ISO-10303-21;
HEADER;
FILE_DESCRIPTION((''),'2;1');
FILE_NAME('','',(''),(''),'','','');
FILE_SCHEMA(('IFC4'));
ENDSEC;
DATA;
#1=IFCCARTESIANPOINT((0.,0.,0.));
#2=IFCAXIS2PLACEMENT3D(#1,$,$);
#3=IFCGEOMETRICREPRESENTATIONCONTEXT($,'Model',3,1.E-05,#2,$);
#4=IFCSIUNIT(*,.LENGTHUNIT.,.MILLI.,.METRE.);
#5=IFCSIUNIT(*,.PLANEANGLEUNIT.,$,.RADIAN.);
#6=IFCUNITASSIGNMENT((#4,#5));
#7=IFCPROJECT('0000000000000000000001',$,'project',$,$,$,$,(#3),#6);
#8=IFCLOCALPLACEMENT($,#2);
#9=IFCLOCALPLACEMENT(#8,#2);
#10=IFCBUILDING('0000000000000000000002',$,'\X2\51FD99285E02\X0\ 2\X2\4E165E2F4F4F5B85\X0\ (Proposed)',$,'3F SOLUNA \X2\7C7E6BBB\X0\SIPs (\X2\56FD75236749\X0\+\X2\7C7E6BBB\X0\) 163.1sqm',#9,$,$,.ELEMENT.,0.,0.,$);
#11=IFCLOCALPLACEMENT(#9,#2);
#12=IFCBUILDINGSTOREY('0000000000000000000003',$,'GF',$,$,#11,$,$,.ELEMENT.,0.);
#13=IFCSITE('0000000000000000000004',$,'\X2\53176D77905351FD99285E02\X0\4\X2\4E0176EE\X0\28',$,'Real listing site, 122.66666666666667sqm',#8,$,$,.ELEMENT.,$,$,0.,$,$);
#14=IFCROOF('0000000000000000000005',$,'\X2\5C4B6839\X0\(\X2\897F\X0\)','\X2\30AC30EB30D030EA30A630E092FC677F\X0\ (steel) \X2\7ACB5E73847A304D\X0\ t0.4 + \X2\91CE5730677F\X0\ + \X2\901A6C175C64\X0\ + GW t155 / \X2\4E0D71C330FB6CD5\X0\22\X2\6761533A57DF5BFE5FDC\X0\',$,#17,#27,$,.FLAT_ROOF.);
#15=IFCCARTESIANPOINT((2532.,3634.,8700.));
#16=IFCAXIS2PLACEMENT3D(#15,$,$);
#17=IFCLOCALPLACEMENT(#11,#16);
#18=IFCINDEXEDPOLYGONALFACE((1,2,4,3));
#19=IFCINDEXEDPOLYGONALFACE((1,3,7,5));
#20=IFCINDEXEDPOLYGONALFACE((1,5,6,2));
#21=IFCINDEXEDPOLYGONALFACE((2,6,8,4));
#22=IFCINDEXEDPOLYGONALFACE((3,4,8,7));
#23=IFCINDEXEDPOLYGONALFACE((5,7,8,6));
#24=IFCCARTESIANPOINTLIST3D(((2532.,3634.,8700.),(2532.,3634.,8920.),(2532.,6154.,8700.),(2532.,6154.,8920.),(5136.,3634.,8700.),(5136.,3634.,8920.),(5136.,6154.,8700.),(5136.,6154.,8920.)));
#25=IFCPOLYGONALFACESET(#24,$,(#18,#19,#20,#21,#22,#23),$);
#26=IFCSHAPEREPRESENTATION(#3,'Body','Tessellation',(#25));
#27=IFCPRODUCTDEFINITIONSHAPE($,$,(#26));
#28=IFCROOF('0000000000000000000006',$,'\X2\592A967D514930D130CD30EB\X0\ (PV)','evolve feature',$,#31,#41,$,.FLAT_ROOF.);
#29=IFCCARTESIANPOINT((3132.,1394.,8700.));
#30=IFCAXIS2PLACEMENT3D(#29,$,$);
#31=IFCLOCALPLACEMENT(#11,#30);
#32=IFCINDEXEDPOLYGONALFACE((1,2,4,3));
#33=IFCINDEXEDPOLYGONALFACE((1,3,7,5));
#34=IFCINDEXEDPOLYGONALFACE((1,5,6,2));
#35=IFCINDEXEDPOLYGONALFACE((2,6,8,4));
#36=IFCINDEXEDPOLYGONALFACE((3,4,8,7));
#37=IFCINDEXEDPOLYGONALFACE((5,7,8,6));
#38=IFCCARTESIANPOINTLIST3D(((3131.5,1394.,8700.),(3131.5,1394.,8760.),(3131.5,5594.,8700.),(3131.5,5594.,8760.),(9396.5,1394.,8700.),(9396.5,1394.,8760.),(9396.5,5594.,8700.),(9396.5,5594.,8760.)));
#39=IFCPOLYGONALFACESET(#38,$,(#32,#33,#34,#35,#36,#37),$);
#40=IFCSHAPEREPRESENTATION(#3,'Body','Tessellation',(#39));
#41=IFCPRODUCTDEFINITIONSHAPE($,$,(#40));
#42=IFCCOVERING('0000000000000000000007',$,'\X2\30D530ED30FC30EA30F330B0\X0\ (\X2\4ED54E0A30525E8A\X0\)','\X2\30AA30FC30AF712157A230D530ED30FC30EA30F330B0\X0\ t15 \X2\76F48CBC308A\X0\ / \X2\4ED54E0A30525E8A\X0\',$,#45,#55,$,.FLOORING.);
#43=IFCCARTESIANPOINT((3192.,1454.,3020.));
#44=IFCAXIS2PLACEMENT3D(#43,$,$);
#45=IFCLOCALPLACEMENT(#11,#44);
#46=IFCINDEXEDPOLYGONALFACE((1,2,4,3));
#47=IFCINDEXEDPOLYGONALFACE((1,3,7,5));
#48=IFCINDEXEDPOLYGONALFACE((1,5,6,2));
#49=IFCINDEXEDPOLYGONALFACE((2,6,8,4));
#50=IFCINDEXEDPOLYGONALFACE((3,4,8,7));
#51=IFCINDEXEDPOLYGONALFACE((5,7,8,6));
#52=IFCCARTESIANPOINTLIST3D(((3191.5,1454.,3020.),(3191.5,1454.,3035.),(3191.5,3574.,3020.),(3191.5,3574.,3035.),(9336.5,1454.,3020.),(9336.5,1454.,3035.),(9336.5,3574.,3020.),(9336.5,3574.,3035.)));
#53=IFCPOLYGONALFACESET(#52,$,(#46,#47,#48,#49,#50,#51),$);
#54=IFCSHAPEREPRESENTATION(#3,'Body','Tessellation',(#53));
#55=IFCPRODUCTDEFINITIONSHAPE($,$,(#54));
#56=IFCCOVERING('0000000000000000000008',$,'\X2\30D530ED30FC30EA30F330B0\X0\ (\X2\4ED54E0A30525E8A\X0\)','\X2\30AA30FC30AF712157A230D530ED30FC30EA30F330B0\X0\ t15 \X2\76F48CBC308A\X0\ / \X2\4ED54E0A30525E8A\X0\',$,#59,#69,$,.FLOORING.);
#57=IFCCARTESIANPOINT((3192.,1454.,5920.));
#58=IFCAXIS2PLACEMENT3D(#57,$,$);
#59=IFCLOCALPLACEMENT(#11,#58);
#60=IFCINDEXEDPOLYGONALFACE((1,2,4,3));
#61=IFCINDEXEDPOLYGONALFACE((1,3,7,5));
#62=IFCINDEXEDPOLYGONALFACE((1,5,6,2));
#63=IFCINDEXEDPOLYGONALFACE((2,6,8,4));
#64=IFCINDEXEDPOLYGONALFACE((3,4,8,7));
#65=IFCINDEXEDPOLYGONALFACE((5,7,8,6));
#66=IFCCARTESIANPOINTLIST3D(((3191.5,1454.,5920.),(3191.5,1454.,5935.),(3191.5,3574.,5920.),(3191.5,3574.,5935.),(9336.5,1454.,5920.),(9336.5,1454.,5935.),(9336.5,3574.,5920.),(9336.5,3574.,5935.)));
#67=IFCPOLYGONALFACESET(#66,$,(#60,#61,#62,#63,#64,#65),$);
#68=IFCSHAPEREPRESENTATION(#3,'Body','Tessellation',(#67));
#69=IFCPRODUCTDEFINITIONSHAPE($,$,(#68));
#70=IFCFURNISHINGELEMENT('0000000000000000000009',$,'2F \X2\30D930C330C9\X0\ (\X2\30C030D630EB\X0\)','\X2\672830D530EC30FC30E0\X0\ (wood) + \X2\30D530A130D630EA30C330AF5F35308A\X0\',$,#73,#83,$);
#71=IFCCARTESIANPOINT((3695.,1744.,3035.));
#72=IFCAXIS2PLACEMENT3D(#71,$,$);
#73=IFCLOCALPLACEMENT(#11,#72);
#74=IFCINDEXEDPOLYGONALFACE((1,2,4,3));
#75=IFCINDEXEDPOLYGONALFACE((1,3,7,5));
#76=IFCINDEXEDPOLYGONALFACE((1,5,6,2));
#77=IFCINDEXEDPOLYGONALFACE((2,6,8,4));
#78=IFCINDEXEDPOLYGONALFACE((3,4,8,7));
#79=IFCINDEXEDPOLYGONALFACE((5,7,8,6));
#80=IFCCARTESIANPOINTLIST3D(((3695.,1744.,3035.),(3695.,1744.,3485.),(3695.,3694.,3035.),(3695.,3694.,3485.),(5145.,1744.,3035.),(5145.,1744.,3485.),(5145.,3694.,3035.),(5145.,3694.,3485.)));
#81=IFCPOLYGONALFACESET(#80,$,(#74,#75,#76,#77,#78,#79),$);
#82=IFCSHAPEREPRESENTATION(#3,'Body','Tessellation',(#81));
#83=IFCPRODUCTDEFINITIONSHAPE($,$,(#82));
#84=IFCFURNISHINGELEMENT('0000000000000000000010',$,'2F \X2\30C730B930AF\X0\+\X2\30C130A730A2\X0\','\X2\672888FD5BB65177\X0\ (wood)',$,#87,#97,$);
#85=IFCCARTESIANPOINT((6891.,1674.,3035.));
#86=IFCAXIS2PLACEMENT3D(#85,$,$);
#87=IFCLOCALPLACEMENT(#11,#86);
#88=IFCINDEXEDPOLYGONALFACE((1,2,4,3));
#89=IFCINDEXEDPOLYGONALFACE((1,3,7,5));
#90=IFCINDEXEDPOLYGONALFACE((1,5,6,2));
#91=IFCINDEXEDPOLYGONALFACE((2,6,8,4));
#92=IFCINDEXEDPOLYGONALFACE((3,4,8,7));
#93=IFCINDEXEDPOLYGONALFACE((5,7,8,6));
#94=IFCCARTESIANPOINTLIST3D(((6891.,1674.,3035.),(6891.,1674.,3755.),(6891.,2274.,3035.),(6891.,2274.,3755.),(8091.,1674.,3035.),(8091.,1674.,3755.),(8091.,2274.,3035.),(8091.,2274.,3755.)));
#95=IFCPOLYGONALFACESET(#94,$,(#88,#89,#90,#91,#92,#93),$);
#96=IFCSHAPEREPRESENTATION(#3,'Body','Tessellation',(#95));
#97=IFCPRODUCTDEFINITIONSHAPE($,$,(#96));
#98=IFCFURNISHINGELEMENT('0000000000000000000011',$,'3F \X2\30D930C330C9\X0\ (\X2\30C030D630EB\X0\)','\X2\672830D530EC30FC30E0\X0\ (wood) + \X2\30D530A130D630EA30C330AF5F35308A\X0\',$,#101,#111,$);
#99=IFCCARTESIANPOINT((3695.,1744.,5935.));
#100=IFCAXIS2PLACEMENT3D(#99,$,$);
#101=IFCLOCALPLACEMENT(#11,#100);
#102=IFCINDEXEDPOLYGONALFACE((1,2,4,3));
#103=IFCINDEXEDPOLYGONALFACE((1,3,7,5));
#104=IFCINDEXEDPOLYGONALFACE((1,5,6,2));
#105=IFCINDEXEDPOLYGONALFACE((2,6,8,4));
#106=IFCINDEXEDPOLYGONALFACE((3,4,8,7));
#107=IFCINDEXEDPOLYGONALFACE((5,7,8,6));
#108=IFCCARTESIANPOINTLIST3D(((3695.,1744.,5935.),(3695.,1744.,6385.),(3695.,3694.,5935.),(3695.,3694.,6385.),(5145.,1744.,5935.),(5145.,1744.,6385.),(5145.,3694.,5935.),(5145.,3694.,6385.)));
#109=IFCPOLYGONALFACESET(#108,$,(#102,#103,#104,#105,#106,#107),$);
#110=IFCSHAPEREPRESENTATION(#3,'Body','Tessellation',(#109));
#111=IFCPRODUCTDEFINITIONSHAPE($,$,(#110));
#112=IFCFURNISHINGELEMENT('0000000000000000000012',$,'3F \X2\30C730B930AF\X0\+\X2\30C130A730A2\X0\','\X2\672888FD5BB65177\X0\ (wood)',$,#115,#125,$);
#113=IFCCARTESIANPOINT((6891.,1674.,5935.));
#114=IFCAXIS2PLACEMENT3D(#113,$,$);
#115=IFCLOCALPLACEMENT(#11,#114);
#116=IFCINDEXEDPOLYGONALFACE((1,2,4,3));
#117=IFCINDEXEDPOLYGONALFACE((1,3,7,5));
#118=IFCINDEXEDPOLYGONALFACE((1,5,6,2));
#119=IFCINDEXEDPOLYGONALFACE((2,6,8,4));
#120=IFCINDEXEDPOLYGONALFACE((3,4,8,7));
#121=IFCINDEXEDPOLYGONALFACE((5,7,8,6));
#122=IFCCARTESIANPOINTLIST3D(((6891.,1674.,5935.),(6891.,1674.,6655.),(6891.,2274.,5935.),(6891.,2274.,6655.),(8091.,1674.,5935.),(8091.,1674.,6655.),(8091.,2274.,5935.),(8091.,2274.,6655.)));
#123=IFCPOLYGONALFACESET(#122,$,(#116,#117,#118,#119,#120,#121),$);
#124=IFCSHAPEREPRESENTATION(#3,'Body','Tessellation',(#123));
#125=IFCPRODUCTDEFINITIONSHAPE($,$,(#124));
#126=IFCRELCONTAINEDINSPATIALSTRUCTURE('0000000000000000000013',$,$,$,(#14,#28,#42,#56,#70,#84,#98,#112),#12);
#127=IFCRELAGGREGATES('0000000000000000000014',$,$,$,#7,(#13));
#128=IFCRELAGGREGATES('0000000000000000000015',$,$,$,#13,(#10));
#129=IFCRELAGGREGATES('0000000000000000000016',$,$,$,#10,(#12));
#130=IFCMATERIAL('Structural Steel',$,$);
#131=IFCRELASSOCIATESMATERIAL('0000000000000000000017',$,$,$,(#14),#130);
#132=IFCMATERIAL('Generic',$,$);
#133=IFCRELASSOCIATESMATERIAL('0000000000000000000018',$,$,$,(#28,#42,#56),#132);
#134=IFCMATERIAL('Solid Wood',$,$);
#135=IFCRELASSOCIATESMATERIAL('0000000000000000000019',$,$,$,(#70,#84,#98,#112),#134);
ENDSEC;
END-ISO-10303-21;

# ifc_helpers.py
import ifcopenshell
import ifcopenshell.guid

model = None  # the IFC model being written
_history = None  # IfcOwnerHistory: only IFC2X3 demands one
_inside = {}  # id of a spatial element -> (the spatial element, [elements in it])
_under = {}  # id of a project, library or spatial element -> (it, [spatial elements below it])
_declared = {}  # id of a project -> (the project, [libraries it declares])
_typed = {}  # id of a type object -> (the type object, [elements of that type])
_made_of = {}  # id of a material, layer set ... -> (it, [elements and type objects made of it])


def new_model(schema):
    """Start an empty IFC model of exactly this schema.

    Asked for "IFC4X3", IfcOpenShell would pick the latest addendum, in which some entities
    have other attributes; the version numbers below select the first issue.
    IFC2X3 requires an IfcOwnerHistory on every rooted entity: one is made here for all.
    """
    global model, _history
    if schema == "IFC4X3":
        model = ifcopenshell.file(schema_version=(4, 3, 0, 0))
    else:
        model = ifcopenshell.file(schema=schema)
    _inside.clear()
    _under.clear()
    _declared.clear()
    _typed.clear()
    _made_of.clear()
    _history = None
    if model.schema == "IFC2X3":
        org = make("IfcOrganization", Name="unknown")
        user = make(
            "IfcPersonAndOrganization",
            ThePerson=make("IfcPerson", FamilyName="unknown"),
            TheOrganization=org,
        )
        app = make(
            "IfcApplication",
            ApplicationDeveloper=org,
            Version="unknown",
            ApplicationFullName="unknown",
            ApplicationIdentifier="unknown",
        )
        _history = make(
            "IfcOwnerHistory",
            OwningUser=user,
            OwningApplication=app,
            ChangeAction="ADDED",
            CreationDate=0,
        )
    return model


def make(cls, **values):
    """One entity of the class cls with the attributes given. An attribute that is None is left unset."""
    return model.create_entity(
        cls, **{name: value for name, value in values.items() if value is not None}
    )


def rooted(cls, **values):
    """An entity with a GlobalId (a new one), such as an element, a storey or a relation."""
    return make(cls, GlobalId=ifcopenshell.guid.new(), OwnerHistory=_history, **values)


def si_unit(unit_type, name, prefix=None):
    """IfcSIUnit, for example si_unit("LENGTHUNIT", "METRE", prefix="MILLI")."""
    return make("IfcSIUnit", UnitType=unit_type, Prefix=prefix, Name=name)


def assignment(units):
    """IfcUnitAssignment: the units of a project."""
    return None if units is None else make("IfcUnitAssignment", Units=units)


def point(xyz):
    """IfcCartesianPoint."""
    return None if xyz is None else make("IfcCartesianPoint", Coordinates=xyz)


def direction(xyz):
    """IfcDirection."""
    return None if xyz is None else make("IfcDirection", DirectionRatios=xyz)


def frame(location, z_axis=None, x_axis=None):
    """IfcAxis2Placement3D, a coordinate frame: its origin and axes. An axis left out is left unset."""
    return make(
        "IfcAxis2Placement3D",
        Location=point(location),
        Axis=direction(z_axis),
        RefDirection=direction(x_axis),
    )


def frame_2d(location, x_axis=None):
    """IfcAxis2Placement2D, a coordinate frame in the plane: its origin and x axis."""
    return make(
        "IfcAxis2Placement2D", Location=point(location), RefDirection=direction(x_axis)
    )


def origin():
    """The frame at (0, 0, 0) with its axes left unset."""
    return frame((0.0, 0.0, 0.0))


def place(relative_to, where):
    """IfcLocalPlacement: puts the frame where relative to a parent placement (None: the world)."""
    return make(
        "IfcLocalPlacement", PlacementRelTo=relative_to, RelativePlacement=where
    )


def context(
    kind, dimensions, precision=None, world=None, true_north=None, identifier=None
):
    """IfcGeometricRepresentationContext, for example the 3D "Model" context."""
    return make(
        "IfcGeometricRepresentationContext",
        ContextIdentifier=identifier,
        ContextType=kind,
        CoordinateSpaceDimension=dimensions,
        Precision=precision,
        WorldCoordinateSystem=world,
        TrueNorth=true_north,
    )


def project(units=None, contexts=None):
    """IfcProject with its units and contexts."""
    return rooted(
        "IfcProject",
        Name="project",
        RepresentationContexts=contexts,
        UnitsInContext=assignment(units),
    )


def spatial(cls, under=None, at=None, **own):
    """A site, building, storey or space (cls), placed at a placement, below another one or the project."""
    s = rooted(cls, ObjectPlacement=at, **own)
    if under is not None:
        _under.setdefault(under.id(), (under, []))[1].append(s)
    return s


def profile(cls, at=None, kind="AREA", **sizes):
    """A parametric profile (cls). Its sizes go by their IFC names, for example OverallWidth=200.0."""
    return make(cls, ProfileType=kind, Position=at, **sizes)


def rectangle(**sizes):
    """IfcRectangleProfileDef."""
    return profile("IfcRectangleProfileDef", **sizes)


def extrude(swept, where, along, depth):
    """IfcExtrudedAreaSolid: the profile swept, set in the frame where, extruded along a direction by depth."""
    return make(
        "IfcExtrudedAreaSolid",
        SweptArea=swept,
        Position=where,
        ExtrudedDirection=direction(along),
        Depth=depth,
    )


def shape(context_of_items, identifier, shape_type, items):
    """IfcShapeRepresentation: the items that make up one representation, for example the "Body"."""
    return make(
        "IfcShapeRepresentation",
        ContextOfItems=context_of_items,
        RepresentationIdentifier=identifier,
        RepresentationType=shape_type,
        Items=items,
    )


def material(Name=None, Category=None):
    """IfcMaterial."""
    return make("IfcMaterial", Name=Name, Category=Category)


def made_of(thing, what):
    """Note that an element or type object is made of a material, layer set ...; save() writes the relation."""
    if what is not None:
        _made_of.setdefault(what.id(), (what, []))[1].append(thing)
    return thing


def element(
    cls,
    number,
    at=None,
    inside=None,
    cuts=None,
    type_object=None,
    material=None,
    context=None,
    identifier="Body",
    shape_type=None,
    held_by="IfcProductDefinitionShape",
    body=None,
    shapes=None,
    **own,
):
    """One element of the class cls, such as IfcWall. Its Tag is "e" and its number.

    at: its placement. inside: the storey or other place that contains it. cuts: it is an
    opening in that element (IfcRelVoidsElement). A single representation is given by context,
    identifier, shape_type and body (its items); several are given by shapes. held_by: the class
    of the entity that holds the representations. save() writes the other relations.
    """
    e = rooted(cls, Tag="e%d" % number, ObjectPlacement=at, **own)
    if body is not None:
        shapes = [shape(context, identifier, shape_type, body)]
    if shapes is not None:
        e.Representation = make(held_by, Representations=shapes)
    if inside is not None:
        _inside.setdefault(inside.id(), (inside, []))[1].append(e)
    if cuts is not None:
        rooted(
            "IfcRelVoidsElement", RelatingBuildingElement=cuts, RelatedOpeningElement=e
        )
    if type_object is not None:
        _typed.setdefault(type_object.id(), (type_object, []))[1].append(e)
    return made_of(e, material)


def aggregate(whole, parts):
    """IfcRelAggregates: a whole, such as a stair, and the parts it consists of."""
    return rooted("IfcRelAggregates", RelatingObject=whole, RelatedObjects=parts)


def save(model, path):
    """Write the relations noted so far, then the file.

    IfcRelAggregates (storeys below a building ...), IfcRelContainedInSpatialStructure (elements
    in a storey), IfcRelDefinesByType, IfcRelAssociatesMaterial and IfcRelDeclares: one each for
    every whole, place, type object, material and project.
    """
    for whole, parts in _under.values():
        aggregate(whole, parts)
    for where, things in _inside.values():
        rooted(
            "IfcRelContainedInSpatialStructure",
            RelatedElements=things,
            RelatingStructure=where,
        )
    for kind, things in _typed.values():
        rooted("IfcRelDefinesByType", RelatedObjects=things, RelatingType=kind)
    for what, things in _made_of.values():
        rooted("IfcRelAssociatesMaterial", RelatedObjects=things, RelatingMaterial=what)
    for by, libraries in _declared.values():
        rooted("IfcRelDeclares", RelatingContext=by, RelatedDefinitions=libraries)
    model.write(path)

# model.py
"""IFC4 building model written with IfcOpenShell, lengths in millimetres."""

from ifc_helpers import new_model, si_unit, frame, frame_2d, origin, place, context, project, spatial, rectangle, extrude, material, element, save


model = new_model("IFC4")

# Units and contexts
model_context = context("Model", 3, precision=1e-05, world=origin())
ifc_project = project(units=[si_unit("LENGTHUNIT", "METRE", prefix="MILLI"), si_unit("PLANEANGLEUNIT", "RADIAN")], contexts=[model_context])

# Site, building, storey
site_placement = place(None, origin())
site = spatial("IfcSite", under=ifc_project, at=site_placement, Name="北海道函館市4丁目28", ObjectType="Real listing site, 122.66666666666667sqm", CompositionType="ELEMENT", RefElevation=0.0)
building_placement = place(site_placement, origin())
building = spatial("IfcBuilding", under=site, at=building_placement, Name="函館市 2世帯住宅 (Proposed)", ObjectType="3F SOLUNA 籾殻SIPs (国産杉+籾殻) 163.1sqm", CompositionType="ELEMENT", ElevationOfRefHeight=0.0, ElevationOfTerrain=0.0)
storey_placement = place(building_placement, origin())
storey = spatial("IfcBuildingStorey", under=building, at=storey_placement, Name="GF", CompositionType="ELEMENT", Elevation=0.0)

# Shared definitions
ifc_material_1 = material(Name="Solid Wood")

# Roofs
ifc_material_2 = material(Name="Structural Steel")
roof_1_placement = place(storey_placement, frame((2532.0, 3634.0, 8700.0)))
element("IfcRoof", 1, at=roof_1_placement, inside=storey, material=ifc_material_2, Name="屋根(西)", Description="ガルバリウム鋼板 (steel) 立平葺き t0.4 + 野地板 + 通気層 + GW t155 / 不燃・法22条区域対応", PredefinedType="FLAT_ROOF", context=model_context, shape_type="SweptSolid", body=[
    extrude(rectangle(XDim=2604.0, YDim=2520.0, at=frame_2d((1302.0, 1260.0))), frame((2532.0, 3634.0, 8700.0)), (0.0, 0.0, 1.0), 220.0),
])
ifc_material_3 = material(Name="Generic")
roof_2_placement = place(storey_placement, frame((3132.0, 1394.0, 8700.0)))
element("IfcRoof", 2, at=roof_2_placement, inside=storey, material=ifc_material_3, Name="太陽光パネル (PV)", Description="evolve feature", PredefinedType="FLAT_ROOF", context=model_context, shape_type="SweptSolid", body=[
    extrude(rectangle(XDim=6265.0, YDim=4200.0, at=frame_2d((3132.0, 2100.0))), frame((3132.0, 1394.0, 8700.0)), (0.0, 0.0, 1.0), 60.0),
])

# Coverings
covering_1_placement = place(storey_placement, frame((3192.0, 1454.0, 3020.0)))
element("IfcCovering", 3, at=covering_1_placement, inside=storey, material=ifc_material_3, Name="フローリング (仕上げ床)", Description="オーク無垢フローリング t15 直貼り / 仕上げ床", PredefinedType="FLOORING", context=model_context, shape_type="SweptSolid", body=[
    extrude(rectangle(XDim=6145.0, YDim=2120.0, at=frame_2d((3072.0, 1060.0))), frame((3192.0, 1454.0, 3020.0)), (0.0, 0.0, 1.0), 15.0),
])
covering_2_placement = place(storey_placement, frame((3192.0, 1454.0, 5920.0)))
element("IfcCovering", 4, at=covering_2_placement, inside=storey, material=ifc_material_3, Name="フローリング (仕上げ床)", Description="オーク無垢フローリング t15 直貼り / 仕上げ床", PredefinedType="FLOORING", context=model_context, shape_type="SweptSolid", body=[
    extrude(rectangle(XDim=6145.0, YDim=2120.0, at=frame_2d((3072.0, 1060.0))), frame((3192.0, 1454.0, 5920.0)), (0.0, 0.0, 1.0), 15.0),
])

# Furnishing elements
furnishing_1_placement = place(storey_placement, frame((3695.0, 1744.0, 3035.0)))
element("IfcFurnishingElement", 5, at=furnishing_1_placement, inside=storey, material=ifc_material_1, Name="2F ベッド (ダブル)", Description="木フレーム (wood) + ファブリック張り", context=model_context, shape_type="SweptSolid", body=[
    extrude(rectangle(XDim=1450.0, YDim=1950.0, at=frame_2d((725.0, 975.0))), frame((3695.0, 1744.0, 3035.0)), (0.0, 0.0, 1.0), 450.0),
])
furnishing_2_placement = place(storey_placement, frame((6891.0, 1674.0, 3035.0)))
element("IfcFurnishingElement", 6, at=furnishing_2_placement, inside=storey, material=ifc_material_1, Name="2F デスク+チェア", Description="木製家具 (wood)", context=model_context, shape_type="SweptSolid", body=[
    extrude(rectangle(XDim=1200.0, YDim=600.0, at=frame_2d((600.0, 300.0))), frame((6891.0, 1674.0, 3035.0)), (0.0, 0.0, 1.0), 720.0),
])
furnishing_3_placement = place(storey_placement, frame((3695.0, 1744.0, 5935.0)))
element("IfcFurnishingElement", 7, at=furnishing_3_placement, inside=storey, material=ifc_material_1, Name="3F ベッド (ダブル)", Description="木フレーム (wood) + ファブリック張り", context=model_context, shape_type="SweptSolid", body=[
    extrude(rectangle(XDim=1450.0, YDim=1950.0, at=frame_2d((725.0, 975.0))), frame((3695.0, 1744.0, 5935.0)), (0.0, 0.0, 1.0), 450.0),
])
furnishing_4_placement = place(storey_placement, frame((6891.0, 1674.0, 5935.0)))
element("IfcFurnishingElement", 8, at=furnishing_4_placement, inside=storey, material=ifc_material_1, Name="3F デスク+チェア", Description="木製家具 (wood)", context=model_context, shape_type="SweptSolid", body=[
    extrude(rectangle(XDim=1200.0, YDim=600.0, at=frame_2d((600.0, 300.0))), frame((6891.0, 1674.0, 5935.0)), (0.0, 0.0, 1.0), 720.0),
])

save(model, "model.ifc")
